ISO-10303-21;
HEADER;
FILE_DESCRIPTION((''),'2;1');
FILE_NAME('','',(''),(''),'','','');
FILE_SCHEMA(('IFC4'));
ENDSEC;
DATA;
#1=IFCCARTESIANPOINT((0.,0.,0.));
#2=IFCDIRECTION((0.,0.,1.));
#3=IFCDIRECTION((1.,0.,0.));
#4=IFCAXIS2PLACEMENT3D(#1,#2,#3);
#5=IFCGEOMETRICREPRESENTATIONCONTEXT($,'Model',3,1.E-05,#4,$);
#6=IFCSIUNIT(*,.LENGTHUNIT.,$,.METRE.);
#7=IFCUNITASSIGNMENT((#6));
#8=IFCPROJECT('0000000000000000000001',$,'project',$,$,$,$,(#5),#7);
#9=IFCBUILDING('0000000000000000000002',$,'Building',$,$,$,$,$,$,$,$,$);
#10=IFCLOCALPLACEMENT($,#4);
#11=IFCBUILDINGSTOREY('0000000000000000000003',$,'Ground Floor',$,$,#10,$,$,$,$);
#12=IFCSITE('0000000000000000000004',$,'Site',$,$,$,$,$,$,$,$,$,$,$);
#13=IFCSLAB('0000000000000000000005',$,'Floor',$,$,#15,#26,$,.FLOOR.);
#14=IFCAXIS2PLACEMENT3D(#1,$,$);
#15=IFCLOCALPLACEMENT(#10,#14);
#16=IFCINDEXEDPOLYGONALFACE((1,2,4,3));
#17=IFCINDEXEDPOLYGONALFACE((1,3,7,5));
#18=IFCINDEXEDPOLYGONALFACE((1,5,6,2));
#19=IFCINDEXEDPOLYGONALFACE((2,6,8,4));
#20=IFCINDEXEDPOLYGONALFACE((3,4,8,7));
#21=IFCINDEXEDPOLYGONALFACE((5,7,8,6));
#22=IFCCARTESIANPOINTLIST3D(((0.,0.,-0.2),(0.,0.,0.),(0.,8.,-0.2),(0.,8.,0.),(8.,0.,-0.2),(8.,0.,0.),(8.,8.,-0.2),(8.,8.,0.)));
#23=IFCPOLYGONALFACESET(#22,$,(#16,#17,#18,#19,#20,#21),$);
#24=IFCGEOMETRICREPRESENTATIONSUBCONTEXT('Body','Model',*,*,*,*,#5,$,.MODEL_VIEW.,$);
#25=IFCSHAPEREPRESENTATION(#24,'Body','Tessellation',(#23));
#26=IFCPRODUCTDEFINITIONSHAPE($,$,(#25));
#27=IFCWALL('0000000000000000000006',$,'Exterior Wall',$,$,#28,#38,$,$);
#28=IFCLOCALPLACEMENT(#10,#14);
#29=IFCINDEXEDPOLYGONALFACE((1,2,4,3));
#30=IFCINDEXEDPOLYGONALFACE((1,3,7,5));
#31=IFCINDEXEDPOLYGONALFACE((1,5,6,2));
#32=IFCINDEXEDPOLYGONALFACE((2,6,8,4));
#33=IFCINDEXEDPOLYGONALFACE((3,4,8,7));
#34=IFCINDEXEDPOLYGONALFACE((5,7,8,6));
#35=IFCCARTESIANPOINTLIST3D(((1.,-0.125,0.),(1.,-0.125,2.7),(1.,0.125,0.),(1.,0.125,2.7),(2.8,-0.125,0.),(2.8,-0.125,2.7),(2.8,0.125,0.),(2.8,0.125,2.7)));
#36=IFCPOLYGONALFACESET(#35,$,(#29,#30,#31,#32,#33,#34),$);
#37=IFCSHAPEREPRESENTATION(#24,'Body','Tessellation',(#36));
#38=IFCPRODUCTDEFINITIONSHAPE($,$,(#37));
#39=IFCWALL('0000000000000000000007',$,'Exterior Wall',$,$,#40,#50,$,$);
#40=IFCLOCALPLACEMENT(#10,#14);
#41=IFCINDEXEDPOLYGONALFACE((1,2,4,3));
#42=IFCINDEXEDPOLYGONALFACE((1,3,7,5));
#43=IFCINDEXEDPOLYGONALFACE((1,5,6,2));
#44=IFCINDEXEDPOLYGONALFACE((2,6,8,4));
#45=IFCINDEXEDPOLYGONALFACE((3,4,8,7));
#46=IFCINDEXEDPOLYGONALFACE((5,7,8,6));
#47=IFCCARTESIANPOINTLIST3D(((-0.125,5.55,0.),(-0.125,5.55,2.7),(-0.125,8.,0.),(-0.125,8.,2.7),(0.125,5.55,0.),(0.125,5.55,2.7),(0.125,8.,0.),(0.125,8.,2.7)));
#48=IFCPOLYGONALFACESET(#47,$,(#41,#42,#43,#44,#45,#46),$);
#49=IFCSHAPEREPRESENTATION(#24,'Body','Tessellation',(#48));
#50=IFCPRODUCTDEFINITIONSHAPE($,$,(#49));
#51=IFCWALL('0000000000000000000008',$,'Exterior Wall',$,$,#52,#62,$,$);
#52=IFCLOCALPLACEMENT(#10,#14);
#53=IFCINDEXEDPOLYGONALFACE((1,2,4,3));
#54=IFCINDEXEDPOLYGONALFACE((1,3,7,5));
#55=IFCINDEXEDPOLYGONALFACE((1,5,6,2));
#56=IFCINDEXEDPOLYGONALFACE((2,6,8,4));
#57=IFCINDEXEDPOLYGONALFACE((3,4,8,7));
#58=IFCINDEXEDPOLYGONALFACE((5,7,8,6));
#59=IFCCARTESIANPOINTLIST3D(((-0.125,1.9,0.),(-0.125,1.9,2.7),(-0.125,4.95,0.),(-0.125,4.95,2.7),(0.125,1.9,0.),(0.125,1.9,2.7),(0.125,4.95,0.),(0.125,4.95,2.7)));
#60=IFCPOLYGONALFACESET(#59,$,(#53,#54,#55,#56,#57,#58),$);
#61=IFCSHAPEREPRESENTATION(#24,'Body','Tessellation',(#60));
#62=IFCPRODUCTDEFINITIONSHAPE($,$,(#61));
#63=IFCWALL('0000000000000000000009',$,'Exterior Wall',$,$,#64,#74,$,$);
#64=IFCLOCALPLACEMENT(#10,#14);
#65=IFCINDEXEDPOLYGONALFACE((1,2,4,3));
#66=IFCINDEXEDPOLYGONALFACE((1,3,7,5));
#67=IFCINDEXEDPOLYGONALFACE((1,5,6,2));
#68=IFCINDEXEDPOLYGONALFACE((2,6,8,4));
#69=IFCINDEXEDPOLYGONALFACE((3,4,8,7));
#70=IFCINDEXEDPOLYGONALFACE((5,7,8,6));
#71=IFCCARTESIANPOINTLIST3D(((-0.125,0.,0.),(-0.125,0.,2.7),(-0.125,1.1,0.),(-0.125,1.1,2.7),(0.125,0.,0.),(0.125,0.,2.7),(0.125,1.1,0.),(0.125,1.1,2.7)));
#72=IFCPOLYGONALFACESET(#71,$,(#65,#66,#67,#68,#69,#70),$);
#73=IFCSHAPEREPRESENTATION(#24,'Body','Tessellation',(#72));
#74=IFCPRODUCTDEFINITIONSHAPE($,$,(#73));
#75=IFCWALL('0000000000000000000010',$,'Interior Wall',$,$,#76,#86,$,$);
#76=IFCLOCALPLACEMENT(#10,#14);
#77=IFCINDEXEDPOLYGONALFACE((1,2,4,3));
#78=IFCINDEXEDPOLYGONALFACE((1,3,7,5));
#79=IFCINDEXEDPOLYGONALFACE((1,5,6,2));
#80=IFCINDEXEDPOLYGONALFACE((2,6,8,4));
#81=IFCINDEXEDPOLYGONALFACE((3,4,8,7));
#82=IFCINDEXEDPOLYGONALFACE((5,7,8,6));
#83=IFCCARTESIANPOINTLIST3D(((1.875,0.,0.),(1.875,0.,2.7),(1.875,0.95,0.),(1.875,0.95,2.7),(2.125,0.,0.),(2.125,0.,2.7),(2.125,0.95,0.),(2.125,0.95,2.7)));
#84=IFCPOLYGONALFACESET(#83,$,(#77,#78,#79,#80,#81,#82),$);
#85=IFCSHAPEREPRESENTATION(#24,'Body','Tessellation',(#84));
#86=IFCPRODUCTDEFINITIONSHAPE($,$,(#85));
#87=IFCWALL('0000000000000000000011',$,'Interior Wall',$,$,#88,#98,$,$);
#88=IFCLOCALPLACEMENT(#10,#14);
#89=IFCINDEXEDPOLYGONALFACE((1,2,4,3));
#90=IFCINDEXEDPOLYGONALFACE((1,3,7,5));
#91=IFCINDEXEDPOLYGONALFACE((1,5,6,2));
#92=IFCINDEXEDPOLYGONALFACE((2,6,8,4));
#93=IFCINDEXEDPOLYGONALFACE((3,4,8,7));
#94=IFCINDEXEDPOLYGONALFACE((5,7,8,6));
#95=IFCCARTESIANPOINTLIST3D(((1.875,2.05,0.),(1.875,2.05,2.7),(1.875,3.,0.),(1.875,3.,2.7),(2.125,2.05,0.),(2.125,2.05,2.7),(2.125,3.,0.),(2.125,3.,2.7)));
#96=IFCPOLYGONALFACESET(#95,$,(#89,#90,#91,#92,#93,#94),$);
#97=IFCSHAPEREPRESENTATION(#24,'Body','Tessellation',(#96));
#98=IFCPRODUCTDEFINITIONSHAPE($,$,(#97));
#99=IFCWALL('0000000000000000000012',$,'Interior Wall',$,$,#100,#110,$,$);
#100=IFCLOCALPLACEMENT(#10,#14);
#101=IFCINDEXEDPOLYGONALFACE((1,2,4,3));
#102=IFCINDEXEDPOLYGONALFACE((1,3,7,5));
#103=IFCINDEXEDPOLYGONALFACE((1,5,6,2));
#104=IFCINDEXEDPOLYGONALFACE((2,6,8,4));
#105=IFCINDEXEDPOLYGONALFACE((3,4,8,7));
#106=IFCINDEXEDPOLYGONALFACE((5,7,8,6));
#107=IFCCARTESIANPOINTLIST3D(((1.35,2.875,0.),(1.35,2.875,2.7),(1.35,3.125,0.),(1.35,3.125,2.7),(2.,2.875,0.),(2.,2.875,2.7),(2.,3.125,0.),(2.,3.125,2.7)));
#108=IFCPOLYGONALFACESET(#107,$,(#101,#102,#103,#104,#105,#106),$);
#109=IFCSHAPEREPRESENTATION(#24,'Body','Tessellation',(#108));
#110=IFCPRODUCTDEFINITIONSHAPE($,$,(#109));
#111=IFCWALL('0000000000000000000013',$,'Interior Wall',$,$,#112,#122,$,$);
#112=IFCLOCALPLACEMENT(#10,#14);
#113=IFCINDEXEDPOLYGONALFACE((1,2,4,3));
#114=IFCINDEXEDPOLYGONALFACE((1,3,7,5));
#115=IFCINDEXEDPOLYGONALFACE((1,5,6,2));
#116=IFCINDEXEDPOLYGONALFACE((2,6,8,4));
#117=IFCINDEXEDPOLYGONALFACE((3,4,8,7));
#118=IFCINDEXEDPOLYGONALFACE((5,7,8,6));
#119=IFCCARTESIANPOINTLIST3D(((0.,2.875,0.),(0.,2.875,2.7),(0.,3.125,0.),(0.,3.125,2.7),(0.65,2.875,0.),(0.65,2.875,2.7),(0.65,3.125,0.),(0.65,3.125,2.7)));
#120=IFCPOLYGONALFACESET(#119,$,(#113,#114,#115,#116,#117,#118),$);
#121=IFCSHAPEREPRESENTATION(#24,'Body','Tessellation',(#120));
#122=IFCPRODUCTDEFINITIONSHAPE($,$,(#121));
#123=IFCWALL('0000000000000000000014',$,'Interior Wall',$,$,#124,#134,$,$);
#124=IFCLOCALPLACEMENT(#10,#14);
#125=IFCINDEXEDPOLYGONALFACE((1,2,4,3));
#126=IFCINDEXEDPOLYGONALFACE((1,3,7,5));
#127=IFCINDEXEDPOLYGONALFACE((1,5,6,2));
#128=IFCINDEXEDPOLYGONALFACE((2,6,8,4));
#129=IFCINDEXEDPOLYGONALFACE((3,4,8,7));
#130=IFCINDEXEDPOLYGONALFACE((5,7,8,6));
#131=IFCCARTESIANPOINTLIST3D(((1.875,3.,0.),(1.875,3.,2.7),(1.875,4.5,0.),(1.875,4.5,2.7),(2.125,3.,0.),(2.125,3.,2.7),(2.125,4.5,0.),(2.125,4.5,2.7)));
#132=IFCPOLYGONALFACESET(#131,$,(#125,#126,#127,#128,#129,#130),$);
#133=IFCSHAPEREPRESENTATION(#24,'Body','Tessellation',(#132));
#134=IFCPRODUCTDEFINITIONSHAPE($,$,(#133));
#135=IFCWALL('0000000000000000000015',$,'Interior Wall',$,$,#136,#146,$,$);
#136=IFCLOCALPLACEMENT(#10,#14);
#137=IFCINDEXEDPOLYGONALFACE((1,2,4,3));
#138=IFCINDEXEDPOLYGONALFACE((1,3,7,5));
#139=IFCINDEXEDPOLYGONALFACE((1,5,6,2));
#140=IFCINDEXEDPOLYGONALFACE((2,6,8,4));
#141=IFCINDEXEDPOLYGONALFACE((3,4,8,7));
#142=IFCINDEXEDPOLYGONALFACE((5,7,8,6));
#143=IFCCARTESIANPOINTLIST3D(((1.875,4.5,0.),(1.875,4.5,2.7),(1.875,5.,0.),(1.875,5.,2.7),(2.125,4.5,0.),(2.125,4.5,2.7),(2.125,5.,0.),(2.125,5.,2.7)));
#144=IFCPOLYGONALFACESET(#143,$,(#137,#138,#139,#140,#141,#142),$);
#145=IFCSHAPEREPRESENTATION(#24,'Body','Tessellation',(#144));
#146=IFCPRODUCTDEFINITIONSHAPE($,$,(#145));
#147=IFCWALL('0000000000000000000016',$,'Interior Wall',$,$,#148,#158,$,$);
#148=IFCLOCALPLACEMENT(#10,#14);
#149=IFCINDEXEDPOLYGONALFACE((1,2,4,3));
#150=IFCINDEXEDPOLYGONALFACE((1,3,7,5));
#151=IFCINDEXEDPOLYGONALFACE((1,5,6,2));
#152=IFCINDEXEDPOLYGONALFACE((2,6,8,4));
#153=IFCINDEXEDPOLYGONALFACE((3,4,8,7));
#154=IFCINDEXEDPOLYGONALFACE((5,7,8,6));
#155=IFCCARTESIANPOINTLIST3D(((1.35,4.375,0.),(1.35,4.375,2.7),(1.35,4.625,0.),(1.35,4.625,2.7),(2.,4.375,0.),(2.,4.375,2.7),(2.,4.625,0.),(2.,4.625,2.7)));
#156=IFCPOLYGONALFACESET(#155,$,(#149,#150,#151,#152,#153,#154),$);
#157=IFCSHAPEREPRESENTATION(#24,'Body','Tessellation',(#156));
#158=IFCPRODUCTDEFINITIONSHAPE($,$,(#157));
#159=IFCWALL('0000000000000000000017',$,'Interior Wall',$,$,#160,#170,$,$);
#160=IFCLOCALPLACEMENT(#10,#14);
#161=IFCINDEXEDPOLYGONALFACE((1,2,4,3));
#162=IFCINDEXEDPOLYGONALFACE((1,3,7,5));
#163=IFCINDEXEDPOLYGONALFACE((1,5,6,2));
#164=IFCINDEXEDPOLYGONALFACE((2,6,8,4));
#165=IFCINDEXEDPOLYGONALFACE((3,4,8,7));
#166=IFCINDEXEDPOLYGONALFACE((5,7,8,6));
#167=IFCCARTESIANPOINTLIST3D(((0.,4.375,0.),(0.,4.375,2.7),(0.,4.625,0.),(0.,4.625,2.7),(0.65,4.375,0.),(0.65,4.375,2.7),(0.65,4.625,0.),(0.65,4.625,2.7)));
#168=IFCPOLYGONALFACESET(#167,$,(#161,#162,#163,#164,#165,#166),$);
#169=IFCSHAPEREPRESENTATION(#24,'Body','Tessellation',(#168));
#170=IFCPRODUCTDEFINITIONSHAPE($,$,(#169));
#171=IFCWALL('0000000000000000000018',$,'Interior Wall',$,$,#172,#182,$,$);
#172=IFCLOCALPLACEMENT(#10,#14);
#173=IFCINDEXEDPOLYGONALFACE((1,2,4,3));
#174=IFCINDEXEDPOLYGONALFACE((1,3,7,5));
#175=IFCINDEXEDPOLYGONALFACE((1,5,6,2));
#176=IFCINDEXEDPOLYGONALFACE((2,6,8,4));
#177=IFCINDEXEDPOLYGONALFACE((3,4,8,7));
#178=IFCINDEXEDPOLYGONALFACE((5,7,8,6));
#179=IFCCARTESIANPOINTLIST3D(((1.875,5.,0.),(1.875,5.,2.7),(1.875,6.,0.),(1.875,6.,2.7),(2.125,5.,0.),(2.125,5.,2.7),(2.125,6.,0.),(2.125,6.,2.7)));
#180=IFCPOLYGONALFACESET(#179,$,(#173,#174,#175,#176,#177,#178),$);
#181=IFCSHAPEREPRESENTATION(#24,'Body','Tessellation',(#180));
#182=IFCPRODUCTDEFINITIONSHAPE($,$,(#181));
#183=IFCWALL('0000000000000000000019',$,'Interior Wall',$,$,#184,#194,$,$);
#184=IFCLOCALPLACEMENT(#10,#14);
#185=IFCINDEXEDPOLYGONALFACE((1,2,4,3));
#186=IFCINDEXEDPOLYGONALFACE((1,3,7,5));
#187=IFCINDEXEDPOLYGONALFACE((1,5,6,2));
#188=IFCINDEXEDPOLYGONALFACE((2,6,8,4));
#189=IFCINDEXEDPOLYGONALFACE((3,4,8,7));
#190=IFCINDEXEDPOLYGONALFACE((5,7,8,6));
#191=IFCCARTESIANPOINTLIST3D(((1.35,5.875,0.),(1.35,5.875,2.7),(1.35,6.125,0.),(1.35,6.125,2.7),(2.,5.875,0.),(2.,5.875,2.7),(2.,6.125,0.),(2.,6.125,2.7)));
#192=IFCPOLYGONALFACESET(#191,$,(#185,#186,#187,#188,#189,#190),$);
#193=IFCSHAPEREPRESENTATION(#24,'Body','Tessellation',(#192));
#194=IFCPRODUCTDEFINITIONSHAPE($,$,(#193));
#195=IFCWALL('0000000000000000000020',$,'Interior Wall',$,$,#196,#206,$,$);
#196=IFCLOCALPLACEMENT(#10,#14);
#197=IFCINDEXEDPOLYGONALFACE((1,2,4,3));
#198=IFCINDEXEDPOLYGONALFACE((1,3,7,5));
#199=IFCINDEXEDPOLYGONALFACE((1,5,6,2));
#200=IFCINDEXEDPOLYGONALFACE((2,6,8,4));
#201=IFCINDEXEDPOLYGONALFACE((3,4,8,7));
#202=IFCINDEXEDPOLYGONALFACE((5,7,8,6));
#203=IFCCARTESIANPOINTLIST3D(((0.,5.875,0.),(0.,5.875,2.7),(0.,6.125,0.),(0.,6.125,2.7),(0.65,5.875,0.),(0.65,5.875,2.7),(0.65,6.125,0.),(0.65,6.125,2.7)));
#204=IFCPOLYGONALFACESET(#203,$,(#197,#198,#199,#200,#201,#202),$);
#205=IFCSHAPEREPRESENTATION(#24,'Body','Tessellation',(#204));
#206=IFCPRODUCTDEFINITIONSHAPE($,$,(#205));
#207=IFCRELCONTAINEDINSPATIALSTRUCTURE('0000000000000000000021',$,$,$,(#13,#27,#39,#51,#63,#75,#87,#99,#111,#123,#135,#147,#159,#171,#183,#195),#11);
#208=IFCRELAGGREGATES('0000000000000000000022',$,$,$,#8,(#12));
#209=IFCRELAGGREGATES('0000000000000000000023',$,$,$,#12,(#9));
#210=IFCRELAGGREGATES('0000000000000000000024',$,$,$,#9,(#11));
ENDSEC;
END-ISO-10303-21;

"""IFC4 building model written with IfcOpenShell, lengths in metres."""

from ifc_helpers import new_model, si_unit, frame, origin_with_axes, place, context, subcontext, project, spatial, indexed_curve, outline, extrude, element, save


model = new_model("IFC4")

# Units and contexts
model_context = context("Model", 3, precision=1e-05, world=origin_with_axes())
body_context = subcontext(model_context, "Body", "Model", "MODEL_VIEW")
ifc_project = project(units=[si_unit("LENGTHUNIT", "METRE")], contexts=[model_context])

# Site, building, storey
site = spatial("IfcSite", under=ifc_project, Name="Site")
building = spatial("IfcBuilding", under=site, Name="Building")
storey_placement = place(None, origin_with_axes())
storey = spatial("IfcBuildingStorey", under=building, at=storey_placement, Name="Ground Floor")

# Slab
slab_placement = place(storey_placement, frame((0.0, 0.0, -0.2), z_axis=(0.0, 0.0, 1.0), x_axis=(1.0, 0.0, 0.0)))
element("IfcSlab", 1, at=slab_placement, inside=storey, Name="Floor", PredefinedType="FLOOR", context=body_context, shape_type="SweptSolid", body=[
    extrude(outline(indexed_curve([(0.0, 0.0), (8.0, 0.0), (8.0, 8.0), (0.0, 8.0)])), None, (0.0, 0.0, 1.0), 0.2),
])

# Walls
wall_1_placement = place(storey_placement, frame((1.0, 0.0, 0.0), z_axis=(0.0, 0.0, 1.0), x_axis=(1.0, 0.0, 0.0)))
element("IfcWall", 2, at=wall_1_placement, inside=storey, Name="Exterior Wall", context=body_context, shape_type="SweptSolid", body=[
    extrude(outline(indexed_curve([(0.0, 0.0), (0.0, 0.25), (1.8, 0.25), (1.8, 0.0), (0.0, 0.0)], self_intersect=False)), frame((0.0, -0.125, 0.0), z_axis=(0.0, 0.0, 1.0), x_axis=(1.0, 0.0, 0.0)), (0.0, 0.0, 1.0), 2.7),
])
wall_2_placement = place(storey_placement, frame((0.0, 8.0, 0.0), z_axis=(0.0, 0.0, 1.0), x_axis=(0.0, -1.0, 0.0)))
element("IfcWall", 3, at=wall_2_placement, inside=storey, Name="Exterior Wall", context=body_context, shape_type="SweptSolid", body=[
    extrude(outline(indexed_curve([(0.0, 0.0), (0.0, 0.25), (2.45, 0.25), (2.45, 0.0), (0.0, 0.0)], self_intersect=False)), frame((0.0, -0.125, 0.0), z_axis=(0.0, 0.0, 1.0), x_axis=(1.0, 0.0, 0.0)), (0.0, 0.0, 1.0), 2.7),
])
wall_3_placement = place(storey_placement, frame((0.0, 4.95, 0.0), z_axis=(0.0, 0.0, 1.0), x_axis=(0.0, -1.0, 0.0)))
element("IfcWall", 4, at=wall_3_placement, inside=storey, Name="Exterior Wall", context=body_context, shape_type="SweptSolid", body=[
    extrude(outline(indexed_curve([(0.0, 0.0), (0.0, 0.25), (3.05, 0.25), (3.05, 0.0), (0.0, 0.0)], self_intersect=False)), frame((0.0, -0.125, 0.0), z_axis=(0.0, 0.0, 1.0), x_axis=(1.0, 0.0, 0.0)), (0.0, 0.0, 1.0), 2.7),
])
wall_4_placement = place(storey_placement, frame((0.0, 1.1, 0.0), z_axis=(0.0, 0.0, 1.0), x_axis=(0.0, -1.0, 0.0)))
element("IfcWall", 5, at=wall_4_placement, inside=storey, Name="Exterior Wall", context=body_context, shape_type="SweptSolid", body=[
    extrude(outline(indexed_curve([(0.0, 0.0), (0.0, 0.25), (1.1, 0.25), (1.1, 0.0), (0.0, 0.0)], self_intersect=False)), frame((0.0, -0.125, 0.0), z_axis=(0.0, 0.0, 1.0), x_axis=(1.0, 0.0, 0.0)), (0.0, 0.0, 1.0), 2.7),
])
wall_5_placement = place(storey_placement, frame((2.0, 0.0, 0.0), z_axis=(0.0, 0.0, 1.0), x_axis=(0.0, 1.0, 0.0)))
element("IfcWall", 6, at=wall_5_placement, inside=storey, Name="Interior Wall", context=body_context, shape_type="SweptSolid", body=[
    extrude(outline(indexed_curve([(0.0, 0.0), (0.0, 0.25), (0.95, 0.25), (0.95, 0.0), (0.0, 0.0)], self_intersect=False)), frame((0.0, -0.125, 0.0), z_axis=(0.0, 0.0, 1.0), x_axis=(1.0, 0.0, 0.0)), (0.0, 0.0, 1.0), 2.7),
])
wall_6_placement = place(storey_placement, frame((2.0, 2.05, 0.0), z_axis=(0.0, 0.0, 1.0), x_axis=(0.0, 1.0, 0.0)))
element("IfcWall", 7, at=wall_6_placement, inside=storey, Name="Interior Wall", context=body_context, shape_type="SweptSolid", body=[
    extrude(outline(indexed_curve([(0.0, 0.0), (0.0, 0.25), (0.95, 0.25), (0.95, 0.0), (0.0, 0.0)], self_intersect=False)), frame((0.0, -0.125, 0.0), z_axis=(0.0, 0.0, 1.0), x_axis=(1.0, 0.0, 0.0)), (0.0, 0.0, 1.0), 2.7),
])
for number, where, z_axis, x_axis, name in (
    (8, (2.0, 3.0, 0.0), (0.0, 0.0, 1.0), (-1.0, 0.0, 0.0), "Interior Wall"),
    (9, (0.65, 3.0, 0.0), (0.0, 0.0, 1.0), (-1.0, 0.0, 0.0), "Interior Wall"),
):
    element("IfcWall", number, at=place(storey_placement, frame(where, z_axis=z_axis, x_axis=x_axis)), inside=storey, Name=name, context=body_context, shape_type="SweptSolid", body=[
        extrude(outline(indexed_curve([(0.0, 0.0), (0.0, 0.25), (0.65, 0.25), (0.65, 0.0), (0.0, 0.0)], self_intersect=False)), frame((0.0, -0.125, 0.0), z_axis=(0.0, 0.0, 1.0), x_axis=(1.0, 0.0, 0.0)), (0.0, 0.0, 1.0), 2.7),
    ])
wall_7_placement = place(storey_placement, frame((2.0, 4.5, 0.0), z_axis=(0.0, 0.0, 1.0), x_axis=(0.0, -1.0, 0.0)))
element("IfcWall", 10, at=wall_7_placement, inside=storey, Name="Interior Wall", context=body_context, shape_type="SweptSolid", body=[
    extrude(outline(indexed_curve([(0.0, 0.0), (0.0, 0.25), (1.5, 0.25), (1.5, 0.0), (0.0, 0.0)], self_intersect=False)), frame((0.0, -0.125, 0.0), z_axis=(0.0, 0.0, 1.0), x_axis=(1.0, 0.0, 0.0)), (0.0, 0.0, 1.0), 2.7),
])
wall_8_placement = place(storey_placement, frame((2.0, 5.0, 0.0), z_axis=(0.0, 0.0, 1.0), x_axis=(0.0, -1.0, 0.0)))
element("IfcWall", 11, at=wall_8_placement, inside=storey, Name="Interior Wall", context=body_context, shape_type="SweptSolid", body=[
    extrude(outline(indexed_curve([(0.0, 0.0), (0.0, 0.25), (0.5, 0.25), (0.5, 0.0), (0.0, 0.0)], self_intersect=False)), frame((0.0, -0.125, 0.0), z_axis=(0.0, 0.0, 1.0), x_axis=(1.0, 0.0, 0.0)), (0.0, 0.0, 1.0), 2.7),
])
for number, where, z_axis, x_axis, name in (
    (12, (2.0, 4.5, 0.0), (0.0, 0.0, 1.0), (-1.0, 0.0, 0.0), "Interior Wall"),
    (13, (0.65, 4.5, 0.0), (0.0, 0.0, 1.0), (-1.0, 0.0, 0.0), "Interior Wall"),
):
    element("IfcWall", number, at=place(storey_placement, frame(where, z_axis=z_axis, x_axis=x_axis)), inside=storey, Name=name, context=body_context, shape_type="SweptSolid", body=[
        extrude(outline(indexed_curve([(0.0, 0.0), (0.0, 0.25), (0.65, 0.25), (0.65, 0.0), (0.0, 0.0)], self_intersect=False)), frame((0.0, -0.125, 0.0), z_axis=(0.0, 0.0, 1.0), x_axis=(1.0, 0.0, 0.0)), (0.0, 0.0, 1.0), 2.7),
    ])
wall_9_placement = place(storey_placement, frame((2.0, 5.0, 0.0), z_axis=(0.0, 0.0, 1.0), x_axis=(0.0, 1.0, 0.0)))
element("IfcWall", 14, at=wall_9_placement, inside=storey, Name="Interior Wall", context=body_context, shape_type="SweptSolid", body=[
    extrude(outline(indexed_curve([(0.0, 0.0), (0.0, 0.25), (1.0, 0.25), (1.0, 0.0), (0.0, 0.0)], self_intersect=False)), frame((0.0, -0.125, 0.0), z_axis=(0.0, 0.0, 1.0), x_axis=(1.0, 0.0, 0.0)), (0.0, 0.0, 1.0), 2.7),
])
for number, where, z_axis, x_axis, name in (
    (15, (2.0, 6.0, 0.0), (0.0, 0.0, 1.0), (-1.0, 0.0, 0.0), "Interior Wall"),
    (16, (0.65, 6.0, 0.0), (0.0, 0.0, 1.0), (-1.0, 0.0, 0.0), "Interior Wall"),
):
    element("IfcWall", number, at=place(storey_placement, frame(where, z_axis=z_axis, x_axis=x_axis)), inside=storey, Name=name, context=body_context, shape_type="SweptSolid", body=[
        extrude(outline(indexed_curve([(0.0, 0.0), (0.0, 0.25), (0.65, 0.25), (0.65, 0.0), (0.0, 0.0)], self_intersect=False)), frame((0.0, -0.125, 0.0), z_axis=(0.0, 0.0, 1.0), x_axis=(1.0, 0.0, 0.0)), (0.0, 0.0, 1.0), 2.7),
    ])

save(model, "model.ifc")
